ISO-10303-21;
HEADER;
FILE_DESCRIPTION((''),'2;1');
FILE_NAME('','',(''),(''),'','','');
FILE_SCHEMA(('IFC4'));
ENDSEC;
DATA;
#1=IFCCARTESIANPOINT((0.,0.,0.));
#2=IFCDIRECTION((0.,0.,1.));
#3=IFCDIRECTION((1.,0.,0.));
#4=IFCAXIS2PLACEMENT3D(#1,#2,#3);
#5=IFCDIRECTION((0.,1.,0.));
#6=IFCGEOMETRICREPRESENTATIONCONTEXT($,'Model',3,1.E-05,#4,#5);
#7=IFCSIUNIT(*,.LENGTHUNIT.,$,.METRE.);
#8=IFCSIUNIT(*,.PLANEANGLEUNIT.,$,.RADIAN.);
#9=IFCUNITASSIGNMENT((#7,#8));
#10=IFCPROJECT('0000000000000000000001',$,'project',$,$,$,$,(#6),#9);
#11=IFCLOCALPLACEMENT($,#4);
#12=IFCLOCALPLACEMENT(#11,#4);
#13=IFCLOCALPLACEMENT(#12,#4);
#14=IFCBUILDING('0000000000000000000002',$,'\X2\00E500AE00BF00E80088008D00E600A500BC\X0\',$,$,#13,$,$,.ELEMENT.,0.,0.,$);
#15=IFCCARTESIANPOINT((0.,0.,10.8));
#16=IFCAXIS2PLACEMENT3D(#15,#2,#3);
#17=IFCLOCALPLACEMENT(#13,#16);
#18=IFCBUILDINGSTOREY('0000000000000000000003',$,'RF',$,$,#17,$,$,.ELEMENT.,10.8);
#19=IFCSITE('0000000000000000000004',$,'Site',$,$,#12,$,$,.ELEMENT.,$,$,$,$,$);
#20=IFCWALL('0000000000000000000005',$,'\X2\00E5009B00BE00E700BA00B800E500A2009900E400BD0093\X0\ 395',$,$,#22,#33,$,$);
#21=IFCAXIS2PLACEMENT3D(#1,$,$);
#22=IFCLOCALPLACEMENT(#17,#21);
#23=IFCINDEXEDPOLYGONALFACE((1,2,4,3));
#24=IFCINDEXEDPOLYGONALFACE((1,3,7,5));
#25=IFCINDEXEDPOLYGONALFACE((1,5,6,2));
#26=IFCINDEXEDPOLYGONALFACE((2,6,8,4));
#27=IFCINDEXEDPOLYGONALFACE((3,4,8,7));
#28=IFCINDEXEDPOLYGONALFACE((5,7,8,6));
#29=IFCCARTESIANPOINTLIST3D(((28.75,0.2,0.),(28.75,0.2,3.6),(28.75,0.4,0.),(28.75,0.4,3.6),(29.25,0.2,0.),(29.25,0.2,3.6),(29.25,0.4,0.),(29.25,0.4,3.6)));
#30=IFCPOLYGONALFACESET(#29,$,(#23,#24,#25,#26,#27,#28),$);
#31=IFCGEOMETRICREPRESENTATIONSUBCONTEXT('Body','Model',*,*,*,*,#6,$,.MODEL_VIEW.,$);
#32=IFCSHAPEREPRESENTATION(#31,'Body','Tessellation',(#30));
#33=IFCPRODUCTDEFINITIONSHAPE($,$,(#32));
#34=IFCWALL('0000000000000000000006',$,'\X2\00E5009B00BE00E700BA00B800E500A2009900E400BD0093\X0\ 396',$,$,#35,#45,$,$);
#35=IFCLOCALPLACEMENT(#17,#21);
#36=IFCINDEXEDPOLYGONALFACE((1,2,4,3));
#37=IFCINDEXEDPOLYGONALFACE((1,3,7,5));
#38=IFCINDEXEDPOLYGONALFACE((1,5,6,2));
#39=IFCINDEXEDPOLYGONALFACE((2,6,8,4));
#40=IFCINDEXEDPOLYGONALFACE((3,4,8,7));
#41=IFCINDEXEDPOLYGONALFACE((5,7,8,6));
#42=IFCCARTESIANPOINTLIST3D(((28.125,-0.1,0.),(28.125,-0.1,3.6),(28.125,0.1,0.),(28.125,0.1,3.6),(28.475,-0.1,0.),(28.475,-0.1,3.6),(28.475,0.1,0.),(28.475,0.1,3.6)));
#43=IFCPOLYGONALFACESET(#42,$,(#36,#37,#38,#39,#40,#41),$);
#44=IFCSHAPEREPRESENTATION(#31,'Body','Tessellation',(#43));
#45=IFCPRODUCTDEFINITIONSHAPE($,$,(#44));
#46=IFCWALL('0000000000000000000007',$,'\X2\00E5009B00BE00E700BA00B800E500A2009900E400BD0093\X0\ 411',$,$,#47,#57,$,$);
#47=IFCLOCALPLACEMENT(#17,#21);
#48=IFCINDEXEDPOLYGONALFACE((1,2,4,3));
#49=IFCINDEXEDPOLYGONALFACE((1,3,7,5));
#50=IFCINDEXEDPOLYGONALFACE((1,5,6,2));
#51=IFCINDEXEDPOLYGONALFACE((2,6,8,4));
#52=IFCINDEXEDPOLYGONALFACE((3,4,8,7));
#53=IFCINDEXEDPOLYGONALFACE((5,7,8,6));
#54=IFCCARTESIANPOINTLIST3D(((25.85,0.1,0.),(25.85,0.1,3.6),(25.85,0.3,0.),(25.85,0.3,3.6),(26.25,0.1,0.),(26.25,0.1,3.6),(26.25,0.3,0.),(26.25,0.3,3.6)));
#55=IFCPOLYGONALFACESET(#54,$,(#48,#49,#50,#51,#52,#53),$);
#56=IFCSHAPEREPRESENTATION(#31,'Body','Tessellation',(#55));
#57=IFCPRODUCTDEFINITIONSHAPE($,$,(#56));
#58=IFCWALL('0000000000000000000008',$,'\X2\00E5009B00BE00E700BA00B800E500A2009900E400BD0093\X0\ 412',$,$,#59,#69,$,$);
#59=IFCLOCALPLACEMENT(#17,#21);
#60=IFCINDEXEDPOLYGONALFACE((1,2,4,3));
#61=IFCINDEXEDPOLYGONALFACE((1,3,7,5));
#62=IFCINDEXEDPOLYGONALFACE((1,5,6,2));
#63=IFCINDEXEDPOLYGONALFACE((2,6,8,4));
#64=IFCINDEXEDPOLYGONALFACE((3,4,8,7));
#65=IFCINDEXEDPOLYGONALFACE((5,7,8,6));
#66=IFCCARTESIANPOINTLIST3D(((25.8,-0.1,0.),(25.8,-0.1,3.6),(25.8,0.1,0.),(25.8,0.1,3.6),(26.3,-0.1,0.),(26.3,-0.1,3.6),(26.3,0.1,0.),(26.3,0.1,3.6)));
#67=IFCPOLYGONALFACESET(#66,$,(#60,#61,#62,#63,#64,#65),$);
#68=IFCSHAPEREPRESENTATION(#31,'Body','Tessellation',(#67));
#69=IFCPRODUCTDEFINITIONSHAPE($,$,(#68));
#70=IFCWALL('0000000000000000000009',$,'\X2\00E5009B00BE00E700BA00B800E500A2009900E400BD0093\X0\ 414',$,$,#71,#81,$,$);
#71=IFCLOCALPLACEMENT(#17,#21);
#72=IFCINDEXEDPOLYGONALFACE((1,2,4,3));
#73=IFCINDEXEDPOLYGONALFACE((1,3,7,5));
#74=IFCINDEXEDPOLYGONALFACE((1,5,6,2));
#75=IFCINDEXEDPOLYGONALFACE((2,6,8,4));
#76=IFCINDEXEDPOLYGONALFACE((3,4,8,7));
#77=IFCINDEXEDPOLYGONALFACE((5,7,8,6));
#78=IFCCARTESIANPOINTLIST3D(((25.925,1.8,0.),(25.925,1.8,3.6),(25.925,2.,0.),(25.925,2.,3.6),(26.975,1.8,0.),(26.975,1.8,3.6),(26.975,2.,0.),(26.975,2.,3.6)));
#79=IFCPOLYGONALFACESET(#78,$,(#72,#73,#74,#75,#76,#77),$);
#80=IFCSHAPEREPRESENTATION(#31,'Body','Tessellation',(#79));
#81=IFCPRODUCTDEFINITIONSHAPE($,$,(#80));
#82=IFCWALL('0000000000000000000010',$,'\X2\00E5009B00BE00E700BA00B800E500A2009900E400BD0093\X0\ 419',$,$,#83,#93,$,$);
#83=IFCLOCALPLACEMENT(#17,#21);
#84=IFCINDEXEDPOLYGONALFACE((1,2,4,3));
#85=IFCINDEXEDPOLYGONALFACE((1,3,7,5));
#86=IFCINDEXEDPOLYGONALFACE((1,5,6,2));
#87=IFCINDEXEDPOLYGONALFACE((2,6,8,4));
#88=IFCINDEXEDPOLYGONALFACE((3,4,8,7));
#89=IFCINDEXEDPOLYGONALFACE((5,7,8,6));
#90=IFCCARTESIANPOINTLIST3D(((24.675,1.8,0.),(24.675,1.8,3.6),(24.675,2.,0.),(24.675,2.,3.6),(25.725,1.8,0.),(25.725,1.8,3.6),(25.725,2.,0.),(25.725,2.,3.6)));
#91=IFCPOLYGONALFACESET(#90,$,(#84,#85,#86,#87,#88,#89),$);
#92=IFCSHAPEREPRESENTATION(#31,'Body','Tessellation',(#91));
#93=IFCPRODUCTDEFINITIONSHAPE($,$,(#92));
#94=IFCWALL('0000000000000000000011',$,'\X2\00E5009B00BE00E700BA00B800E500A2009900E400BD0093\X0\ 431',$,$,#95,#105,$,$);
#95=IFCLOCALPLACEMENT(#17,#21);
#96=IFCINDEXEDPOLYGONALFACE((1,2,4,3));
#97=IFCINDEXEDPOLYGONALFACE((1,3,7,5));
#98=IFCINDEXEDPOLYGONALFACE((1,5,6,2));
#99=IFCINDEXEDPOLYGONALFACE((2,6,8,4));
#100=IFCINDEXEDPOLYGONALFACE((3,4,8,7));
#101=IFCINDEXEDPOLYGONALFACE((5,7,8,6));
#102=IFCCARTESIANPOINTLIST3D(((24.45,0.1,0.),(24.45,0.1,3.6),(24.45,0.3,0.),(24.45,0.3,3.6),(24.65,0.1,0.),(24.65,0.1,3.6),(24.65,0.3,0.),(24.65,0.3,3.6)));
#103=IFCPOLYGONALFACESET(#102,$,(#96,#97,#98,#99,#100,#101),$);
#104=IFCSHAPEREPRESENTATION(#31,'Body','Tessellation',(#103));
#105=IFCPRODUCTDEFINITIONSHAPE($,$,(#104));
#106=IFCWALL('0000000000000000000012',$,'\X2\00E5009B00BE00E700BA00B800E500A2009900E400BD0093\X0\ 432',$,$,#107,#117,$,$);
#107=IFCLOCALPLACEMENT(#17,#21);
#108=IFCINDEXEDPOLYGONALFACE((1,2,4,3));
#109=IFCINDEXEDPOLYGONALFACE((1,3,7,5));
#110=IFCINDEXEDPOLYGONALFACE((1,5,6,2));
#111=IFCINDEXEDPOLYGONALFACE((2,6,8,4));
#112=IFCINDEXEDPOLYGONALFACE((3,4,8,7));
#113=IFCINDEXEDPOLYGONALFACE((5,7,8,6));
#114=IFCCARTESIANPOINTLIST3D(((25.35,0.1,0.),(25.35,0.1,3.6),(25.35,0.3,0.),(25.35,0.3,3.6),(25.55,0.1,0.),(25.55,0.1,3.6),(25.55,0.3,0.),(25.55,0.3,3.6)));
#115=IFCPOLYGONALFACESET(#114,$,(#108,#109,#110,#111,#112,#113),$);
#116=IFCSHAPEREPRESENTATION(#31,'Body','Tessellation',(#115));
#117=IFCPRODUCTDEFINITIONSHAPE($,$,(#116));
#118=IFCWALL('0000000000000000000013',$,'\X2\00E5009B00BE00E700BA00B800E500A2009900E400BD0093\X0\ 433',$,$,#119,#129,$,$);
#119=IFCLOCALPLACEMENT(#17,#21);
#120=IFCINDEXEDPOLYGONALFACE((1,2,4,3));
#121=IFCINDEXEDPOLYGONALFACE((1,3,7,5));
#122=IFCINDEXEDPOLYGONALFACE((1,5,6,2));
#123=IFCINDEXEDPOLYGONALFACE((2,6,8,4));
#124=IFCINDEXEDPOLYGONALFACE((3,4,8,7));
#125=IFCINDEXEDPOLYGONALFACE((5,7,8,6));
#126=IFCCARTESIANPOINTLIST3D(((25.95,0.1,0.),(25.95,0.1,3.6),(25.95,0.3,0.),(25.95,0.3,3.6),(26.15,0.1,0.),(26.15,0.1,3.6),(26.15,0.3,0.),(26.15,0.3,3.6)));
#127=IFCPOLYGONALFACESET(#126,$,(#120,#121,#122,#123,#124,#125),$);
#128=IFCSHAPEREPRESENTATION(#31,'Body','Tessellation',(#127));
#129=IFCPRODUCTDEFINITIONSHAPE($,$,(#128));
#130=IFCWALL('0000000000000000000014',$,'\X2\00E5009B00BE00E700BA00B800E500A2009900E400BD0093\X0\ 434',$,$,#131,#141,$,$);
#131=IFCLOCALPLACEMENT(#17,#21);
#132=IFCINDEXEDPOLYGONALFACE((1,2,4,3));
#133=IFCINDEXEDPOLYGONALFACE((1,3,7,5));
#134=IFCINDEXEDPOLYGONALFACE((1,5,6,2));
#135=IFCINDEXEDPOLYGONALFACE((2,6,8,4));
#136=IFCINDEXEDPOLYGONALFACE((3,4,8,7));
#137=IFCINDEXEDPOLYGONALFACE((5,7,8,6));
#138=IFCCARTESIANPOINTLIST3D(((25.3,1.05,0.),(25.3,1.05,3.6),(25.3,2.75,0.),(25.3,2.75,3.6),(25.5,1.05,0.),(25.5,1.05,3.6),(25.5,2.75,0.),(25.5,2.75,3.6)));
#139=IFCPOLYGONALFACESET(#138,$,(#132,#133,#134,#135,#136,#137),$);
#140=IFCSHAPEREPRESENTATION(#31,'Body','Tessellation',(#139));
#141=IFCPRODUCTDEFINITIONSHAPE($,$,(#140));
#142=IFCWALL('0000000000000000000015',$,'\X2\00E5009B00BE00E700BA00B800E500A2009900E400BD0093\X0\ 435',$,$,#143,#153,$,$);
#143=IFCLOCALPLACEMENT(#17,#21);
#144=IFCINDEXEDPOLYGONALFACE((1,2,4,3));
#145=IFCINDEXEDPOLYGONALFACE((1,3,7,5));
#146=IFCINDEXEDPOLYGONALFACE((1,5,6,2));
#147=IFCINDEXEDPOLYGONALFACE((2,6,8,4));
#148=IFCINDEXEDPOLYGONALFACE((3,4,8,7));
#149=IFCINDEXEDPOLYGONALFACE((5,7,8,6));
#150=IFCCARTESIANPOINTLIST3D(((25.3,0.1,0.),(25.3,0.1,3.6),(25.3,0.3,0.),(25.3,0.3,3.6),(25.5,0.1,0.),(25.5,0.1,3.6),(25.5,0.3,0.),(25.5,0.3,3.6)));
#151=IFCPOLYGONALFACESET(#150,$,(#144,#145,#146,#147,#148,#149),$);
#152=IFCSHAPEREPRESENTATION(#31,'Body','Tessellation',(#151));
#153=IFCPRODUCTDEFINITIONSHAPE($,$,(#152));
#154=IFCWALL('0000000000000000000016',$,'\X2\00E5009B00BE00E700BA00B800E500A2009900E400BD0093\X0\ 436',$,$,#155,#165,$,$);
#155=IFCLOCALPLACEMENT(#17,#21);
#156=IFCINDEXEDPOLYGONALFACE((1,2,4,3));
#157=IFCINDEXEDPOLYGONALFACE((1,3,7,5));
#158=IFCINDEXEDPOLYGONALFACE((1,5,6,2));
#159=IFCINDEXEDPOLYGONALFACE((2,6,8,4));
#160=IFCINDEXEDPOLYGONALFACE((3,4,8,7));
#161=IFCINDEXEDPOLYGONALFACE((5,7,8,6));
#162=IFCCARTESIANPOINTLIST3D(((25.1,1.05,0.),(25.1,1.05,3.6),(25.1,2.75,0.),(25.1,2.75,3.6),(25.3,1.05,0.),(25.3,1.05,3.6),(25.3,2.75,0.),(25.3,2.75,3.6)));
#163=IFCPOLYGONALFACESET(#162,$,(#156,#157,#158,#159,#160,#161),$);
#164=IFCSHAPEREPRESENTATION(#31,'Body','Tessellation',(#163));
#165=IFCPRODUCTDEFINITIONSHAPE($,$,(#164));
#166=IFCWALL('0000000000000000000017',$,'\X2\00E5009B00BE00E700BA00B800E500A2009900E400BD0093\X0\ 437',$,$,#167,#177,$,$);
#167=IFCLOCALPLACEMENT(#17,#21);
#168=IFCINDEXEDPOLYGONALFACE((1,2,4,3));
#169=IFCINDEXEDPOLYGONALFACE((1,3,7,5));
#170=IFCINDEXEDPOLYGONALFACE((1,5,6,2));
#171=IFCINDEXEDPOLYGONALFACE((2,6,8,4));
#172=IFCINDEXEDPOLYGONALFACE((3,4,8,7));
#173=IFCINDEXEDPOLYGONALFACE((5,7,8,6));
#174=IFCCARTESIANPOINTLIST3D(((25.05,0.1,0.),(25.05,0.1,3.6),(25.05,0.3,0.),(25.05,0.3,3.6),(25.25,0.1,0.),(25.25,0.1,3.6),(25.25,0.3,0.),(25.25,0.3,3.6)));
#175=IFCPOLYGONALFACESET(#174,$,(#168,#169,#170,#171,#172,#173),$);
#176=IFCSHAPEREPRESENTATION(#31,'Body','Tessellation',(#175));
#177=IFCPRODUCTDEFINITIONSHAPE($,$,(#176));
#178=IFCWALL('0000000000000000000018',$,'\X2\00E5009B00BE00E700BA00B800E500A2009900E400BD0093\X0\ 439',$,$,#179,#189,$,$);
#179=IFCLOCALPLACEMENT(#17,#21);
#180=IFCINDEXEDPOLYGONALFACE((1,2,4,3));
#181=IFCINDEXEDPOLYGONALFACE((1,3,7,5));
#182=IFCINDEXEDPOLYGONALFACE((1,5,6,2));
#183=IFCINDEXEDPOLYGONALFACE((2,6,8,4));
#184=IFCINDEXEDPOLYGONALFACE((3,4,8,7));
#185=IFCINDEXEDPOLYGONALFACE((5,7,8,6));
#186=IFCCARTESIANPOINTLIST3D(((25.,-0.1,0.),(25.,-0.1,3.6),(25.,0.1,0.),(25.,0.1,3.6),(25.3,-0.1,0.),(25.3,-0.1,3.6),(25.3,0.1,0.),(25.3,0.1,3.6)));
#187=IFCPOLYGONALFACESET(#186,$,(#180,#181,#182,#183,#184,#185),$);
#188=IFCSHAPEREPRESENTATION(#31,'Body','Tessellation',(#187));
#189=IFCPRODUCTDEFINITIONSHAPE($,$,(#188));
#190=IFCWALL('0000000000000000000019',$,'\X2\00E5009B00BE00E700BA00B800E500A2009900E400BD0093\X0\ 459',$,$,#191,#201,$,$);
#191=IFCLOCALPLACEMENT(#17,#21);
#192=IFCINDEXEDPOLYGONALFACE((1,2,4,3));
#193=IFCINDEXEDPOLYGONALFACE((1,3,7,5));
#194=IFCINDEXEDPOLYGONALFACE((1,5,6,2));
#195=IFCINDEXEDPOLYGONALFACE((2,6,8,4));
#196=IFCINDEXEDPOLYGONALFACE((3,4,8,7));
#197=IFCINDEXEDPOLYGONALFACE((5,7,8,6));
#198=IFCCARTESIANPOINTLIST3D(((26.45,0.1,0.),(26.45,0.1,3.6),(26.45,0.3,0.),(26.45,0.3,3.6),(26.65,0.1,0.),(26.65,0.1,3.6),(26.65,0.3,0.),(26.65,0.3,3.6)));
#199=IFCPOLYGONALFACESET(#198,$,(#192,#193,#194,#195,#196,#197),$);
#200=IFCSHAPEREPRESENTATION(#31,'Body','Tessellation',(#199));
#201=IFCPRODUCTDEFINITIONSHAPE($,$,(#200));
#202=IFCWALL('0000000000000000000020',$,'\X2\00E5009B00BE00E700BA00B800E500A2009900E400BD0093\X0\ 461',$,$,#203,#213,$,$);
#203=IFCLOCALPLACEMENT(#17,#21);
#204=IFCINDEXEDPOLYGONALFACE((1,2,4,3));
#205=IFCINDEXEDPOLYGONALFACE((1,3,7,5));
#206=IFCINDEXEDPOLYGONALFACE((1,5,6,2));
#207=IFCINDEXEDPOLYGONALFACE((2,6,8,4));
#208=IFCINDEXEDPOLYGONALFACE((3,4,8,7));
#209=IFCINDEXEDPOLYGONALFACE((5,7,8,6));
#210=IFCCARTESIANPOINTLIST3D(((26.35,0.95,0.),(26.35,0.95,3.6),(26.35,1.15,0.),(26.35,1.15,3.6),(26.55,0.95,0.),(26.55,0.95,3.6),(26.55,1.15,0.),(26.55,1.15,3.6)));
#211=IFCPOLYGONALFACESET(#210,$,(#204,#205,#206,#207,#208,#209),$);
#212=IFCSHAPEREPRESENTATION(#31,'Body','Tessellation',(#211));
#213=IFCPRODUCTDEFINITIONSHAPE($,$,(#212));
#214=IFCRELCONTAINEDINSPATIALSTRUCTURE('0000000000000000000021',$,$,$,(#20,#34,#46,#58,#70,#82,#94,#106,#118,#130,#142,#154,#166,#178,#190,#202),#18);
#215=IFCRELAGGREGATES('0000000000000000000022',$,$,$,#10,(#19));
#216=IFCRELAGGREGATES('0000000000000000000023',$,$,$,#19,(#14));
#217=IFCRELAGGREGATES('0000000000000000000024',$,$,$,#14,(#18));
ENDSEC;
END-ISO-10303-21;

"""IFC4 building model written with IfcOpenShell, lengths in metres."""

from ifc_helpers import new_model, si_unit, direction, frame, frame_2d, origin_with_axes, place, context, subcontext, project, spatial, rectangle, extrude, element, save


model = new_model("IFC4")

# Units and contexts
model_context = context("Model", 3, precision=1e-05, world=origin_with_axes(), true_north=direction((0.0, 1.0, 0.0)))
body_context = subcontext(model_context, "Body", "Model", "MODEL_VIEW")
ifc_project = project(units=[si_unit("LENGTHUNIT", "METRE"), si_unit("PLANEANGLEUNIT", "RADIAN")], contexts=[model_context])

# Site, building, storey
placement = place(None, origin_with_axes())
site_placement = place(placement, origin_with_axes())
site = spatial("IfcSite", under=ifc_project, at=site_placement, Name="Site", CompositionType="ELEMENT")
building_placement = place(site_placement, origin_with_axes())
building = spatial("IfcBuilding", under=site, at=building_placement, Name="å®¿è\u0088\u008dæ¥¼", CompositionType="ELEMENT", ElevationOfRefHeight=0.0, ElevationOfTerrain=0.0)
storey_placement = place(building_placement, frame((0.0, 0.0, 10.8), z_axis=(0.0, 0.0, 1.0), x_axis=(1.0, 0.0, 0.0)))
storey = spatial("IfcBuildingStorey", under=building, at=storey_placement, Name="RF", CompositionType="ELEMENT", Elevation=10.8)

# Walls
wall_1_placement = place(storey_placement, frame((29.0, 0.3, 0.0), z_axis=(0.0, 0.0, 1.0), x_axis=(1.0, 0.0, 0.0)))
element("IfcWall", 1, at=wall_1_placement, inside=storey, Name="å\u009b¾çº¸å¢\u0099ä½\u0093 395", context=body_context, shape_type="SweptSolid", body=[
    extrude(rectangle(XDim=0.5, YDim=0.2, at=frame_2d((0.0, 0.0), x_axis=(1.0, 0.0, 0.0))), frame((0.0, 0.0, 0.0), z_axis=(0.0, 0.0, 1.0)), (0.0, 0.0, 1.0), 3.6),
])
wall_2_placement = place(storey_placement, frame((28.3, 0.0, 0.0), z_axis=(0.0, 0.0, 1.0), x_axis=(1.0, 0.0, 0.0)))
element("IfcWall", 2, at=wall_2_placement, inside=storey, Name="å\u009b¾çº¸å¢\u0099ä½\u0093 396", context=body_context, shape_type="SweptSolid", body=[
    extrude(rectangle(XDim=0.35, YDim=0.2, at=frame_2d((0.0, 0.0), x_axis=(1.0, 0.0, 0.0))), frame((0.0, 0.0, 0.0), z_axis=(0.0, 0.0, 1.0)), (0.0, 0.0, 1.0), 3.6),
])
wall_3_placement = place(storey_placement, frame((26.05, 0.2, 0.0), z_axis=(0.0, 0.0, 1.0), x_axis=(1.0, 0.0, 0.0)))
element("IfcWall", 3, at=wall_3_placement, inside=storey, Name="å\u009b¾çº¸å¢\u0099ä½\u0093 411", context=body_context, shape_type="SweptSolid", body=[
    extrude(rectangle(XDim=0.4, YDim=0.2, at=frame_2d((0.0, 0.0), x_axis=(1.0, 0.0, 0.0))), frame((0.0, 0.0, 0.0), z_axis=(0.0, 0.0, 1.0)), (0.0, 0.0, 1.0), 3.6),
])
wall_4_placement = place(storey_placement, frame((26.05, 0.0, 0.0), z_axis=(0.0, 0.0, 1.0), x_axis=(1.0, 0.0, 0.0)))
element("IfcWall", 4, at=wall_4_placement, inside=storey, Name="å\u009b¾çº¸å¢\u0099ä½\u0093 412", context=body_context, shape_type="SweptSolid", body=[
    extrude(rectangle(XDim=0.5, YDim=0.2, at=frame_2d((0.0, 0.0), x_axis=(1.0, 0.0, 0.0))), frame((0.0, 0.0, 0.0), z_axis=(0.0, 0.0, 1.0)), (0.0, 0.0, 1.0), 3.6),
])
for number, where, z_axis, x_axis, name in (
    (5, (26.45, 1.9, 0.0), (0.0, 0.0, 1.0), (-1.0, 0.0, 0.0), "å\u009b¾çº¸å¢\u0099ä½\u0093 414"),
    (6, (25.2, 1.9, 0.0), (0.0, 0.0, 1.0), (-1.0, 0.0, 0.0), "å\u009b¾çº¸å¢\u0099ä½\u0093 419"),
):
    element("IfcWall", number, at=place(storey_placement, frame(where, z_axis=z_axis, x_axis=x_axis)), inside=storey, Name=name, context=body_context, shape_type="SweptSolid", body=[
        extrude(rectangle(XDim=1.05, YDim=0.2, at=frame_2d((0.0, 0.0), x_axis=(1.0, 0.0, 0.0))), frame((0.0, 0.0, 0.0), z_axis=(0.0, 0.0, 1.0)), (0.0, 0.0, 1.0), 3.6),
    ])
for number, where, z_axis, x_axis, name in (
    (7, (24.55, 0.2, 0.0), (0.0, 0.0, 1.0), (0.0, -1.0, 0.0), "å\u009b¾çº¸å¢\u0099ä½\u0093 431"),
    (8, (25.45, 0.2, 0.0), (0.0, 0.0, 1.0), (0.0, -1.0, 0.0), "å\u009b¾çº¸å¢\u0099ä½\u0093 432"),
    (9, (26.05, 0.2, 0.0), (0.0, 0.0, 1.0), (0.0, -1.0, 0.0), "å\u009b¾çº¸å¢\u0099ä½\u0093 433"),
):
    element("IfcWall", number, at=place(storey_placement, frame(where, z_axis=z_axis, x_axis=x_axis)), inside=storey, Name=name, context=body_context, shape_type="SweptSolid", body=[
        extrude(rectangle(XDim=0.2, YDim=0.2, at=frame_2d((0.0, 0.0), x_axis=(1.0, 0.0, 0.0))), frame((0.0, 0.0, 0.0), z_axis=(0.0, 0.0, 1.0)), (0.0, 0.0, 1.0), 3.6),
    ])
wall_5_placement = place(storey_placement, frame((25.4, 1.9, 0.0), z_axis=(0.0, 0.0, 1.0), x_axis=(0.0, -1.0, 0.0)))
element("IfcWall", 10, at=wall_5_placement, inside=storey, Name="å\u009b¾çº¸å¢\u0099ä½\u0093 434", context=body_context, shape_type="SweptSolid", body=[
    extrude(rectangle(XDim=1.7, YDim=0.2, at=frame_2d((0.0, 0.0), x_axis=(1.0, 0.0, 0.0))), frame((0.0, 0.0, 0.0), z_axis=(0.0, 0.0, 1.0)), (0.0, 0.0, 1.0), 3.6),
])
wall_6_placement = place(storey_placement, frame((25.4, 0.2, 0.0), z_axis=(0.0, 0.0, 1.0), x_axis=(1.0, 0.0, 0.0)))
element("IfcWall", 11, at=wall_6_placement, inside=storey, Name="å\u009b¾çº¸å¢\u0099ä½\u0093 435", context=body_context, shape_type="SweptSolid", body=[
    extrude(rectangle(XDim=0.2, YDim=0.2, at=frame_2d((0.0, 0.0), x_axis=(1.0, 0.0, 0.0))), frame((0.0, 0.0, 0.0), z_axis=(0.0, 0.0, 1.0)), (0.0, 0.0, 1.0), 3.6),
])
wall_7_placement = place(storey_placement, frame((25.2, 1.9, 0.0), z_axis=(0.0, 0.0, 1.0), x_axis=(0.0, -1.0, 0.0)))
element("IfcWall", 12, at=wall_7_placement, inside=storey, Name="å\u009b¾çº¸å¢\u0099ä½\u0093 436", context=body_context, shape_type="SweptSolid", body=[
    extrude(rectangle(XDim=1.7, YDim=0.2, at=frame_2d((0.0, 0.0), x_axis=(1.0, 0.0, 0.0))), frame((0.0, 0.0, 0.0), z_axis=(0.0, 0.0, 1.0)), (0.0, 0.0, 1.0), 3.6),
])
for number, where, z_axis, x_axis, name in (
    (13, (25.15, 0.2, 0.0), (0.0, 0.0, 1.0), (1.0, 0.0, 0.0), "å\u009b¾çº¸å¢\u0099ä½\u0093 437"),
):
    element("IfcWall", number, at=place(storey_placement, frame(where, z_axis=z_axis, x_axis=x_axis)), inside=storey, Name=name, context=body_context, shape_type="SweptSolid", body=[
        extrude(rectangle(XDim=0.2, YDim=0.2, at=frame_2d((0.0, 0.0), x_axis=(1.0, 0.0, 0.0))), frame((0.0, 0.0, 0.0), z_axis=(0.0, 0.0, 1.0)), (0.0, 0.0, 1.0), 3.6),
    ])
wall_8_placement = place(storey_placement, frame((25.15, 0.0, 0.0), z_axis=(0.0, 0.0, 1.0), x_axis=(1.0, 0.0, 0.0)))
element("IfcWall", 14, at=wall_8_placement, inside=storey, Name="å\u009b¾çº¸å¢\u0099ä½\u0093 439", context=body_context, shape_type="SweptSolid", body=[
    extrude(rectangle(XDim=0.3, YDim=0.2, at=frame_2d((0.0, 0.0), x_axis=(1.0, 0.0, 0.0))), frame((0.0, 0.0, 0.0), z_axis=(0.0, 0.0, 1.0)), (0.0, 0.0, 1.0), 3.6),
])
for number, where, z_axis, x_axis, name in (
    (15, (26.55, 0.2, 0.0), (0.0, 0.0, 1.0), (0.0, -1.0, 0.0), "å\u009b¾çº¸å¢\u0099ä½\u0093 459"),
    (16, (26.45, 1.05, 0.0), (0.0, 0.0, 1.0), (1.0, 0.0, 0.0), "å\u009b¾çº¸å¢\u0099ä½\u0093 461"),
):
    element("IfcWall", number, at=place(storey_placement, frame(where, z_axis=z_axis, x_axis=x_axis)), inside=storey, Name=name, context=body_context, shape_type="SweptSolid", body=[
        extrude(rectangle(XDim=0.2, YDim=0.2, at=frame_2d((0.0, 0.0), x_axis=(1.0, 0.0, 0.0))), frame((0.0, 0.0, 0.0), z_axis=(0.0, 0.0, 1.0)), (0.0, 0.0, 1.0), 3.6),
    ])

save(model, "model.ifc")
